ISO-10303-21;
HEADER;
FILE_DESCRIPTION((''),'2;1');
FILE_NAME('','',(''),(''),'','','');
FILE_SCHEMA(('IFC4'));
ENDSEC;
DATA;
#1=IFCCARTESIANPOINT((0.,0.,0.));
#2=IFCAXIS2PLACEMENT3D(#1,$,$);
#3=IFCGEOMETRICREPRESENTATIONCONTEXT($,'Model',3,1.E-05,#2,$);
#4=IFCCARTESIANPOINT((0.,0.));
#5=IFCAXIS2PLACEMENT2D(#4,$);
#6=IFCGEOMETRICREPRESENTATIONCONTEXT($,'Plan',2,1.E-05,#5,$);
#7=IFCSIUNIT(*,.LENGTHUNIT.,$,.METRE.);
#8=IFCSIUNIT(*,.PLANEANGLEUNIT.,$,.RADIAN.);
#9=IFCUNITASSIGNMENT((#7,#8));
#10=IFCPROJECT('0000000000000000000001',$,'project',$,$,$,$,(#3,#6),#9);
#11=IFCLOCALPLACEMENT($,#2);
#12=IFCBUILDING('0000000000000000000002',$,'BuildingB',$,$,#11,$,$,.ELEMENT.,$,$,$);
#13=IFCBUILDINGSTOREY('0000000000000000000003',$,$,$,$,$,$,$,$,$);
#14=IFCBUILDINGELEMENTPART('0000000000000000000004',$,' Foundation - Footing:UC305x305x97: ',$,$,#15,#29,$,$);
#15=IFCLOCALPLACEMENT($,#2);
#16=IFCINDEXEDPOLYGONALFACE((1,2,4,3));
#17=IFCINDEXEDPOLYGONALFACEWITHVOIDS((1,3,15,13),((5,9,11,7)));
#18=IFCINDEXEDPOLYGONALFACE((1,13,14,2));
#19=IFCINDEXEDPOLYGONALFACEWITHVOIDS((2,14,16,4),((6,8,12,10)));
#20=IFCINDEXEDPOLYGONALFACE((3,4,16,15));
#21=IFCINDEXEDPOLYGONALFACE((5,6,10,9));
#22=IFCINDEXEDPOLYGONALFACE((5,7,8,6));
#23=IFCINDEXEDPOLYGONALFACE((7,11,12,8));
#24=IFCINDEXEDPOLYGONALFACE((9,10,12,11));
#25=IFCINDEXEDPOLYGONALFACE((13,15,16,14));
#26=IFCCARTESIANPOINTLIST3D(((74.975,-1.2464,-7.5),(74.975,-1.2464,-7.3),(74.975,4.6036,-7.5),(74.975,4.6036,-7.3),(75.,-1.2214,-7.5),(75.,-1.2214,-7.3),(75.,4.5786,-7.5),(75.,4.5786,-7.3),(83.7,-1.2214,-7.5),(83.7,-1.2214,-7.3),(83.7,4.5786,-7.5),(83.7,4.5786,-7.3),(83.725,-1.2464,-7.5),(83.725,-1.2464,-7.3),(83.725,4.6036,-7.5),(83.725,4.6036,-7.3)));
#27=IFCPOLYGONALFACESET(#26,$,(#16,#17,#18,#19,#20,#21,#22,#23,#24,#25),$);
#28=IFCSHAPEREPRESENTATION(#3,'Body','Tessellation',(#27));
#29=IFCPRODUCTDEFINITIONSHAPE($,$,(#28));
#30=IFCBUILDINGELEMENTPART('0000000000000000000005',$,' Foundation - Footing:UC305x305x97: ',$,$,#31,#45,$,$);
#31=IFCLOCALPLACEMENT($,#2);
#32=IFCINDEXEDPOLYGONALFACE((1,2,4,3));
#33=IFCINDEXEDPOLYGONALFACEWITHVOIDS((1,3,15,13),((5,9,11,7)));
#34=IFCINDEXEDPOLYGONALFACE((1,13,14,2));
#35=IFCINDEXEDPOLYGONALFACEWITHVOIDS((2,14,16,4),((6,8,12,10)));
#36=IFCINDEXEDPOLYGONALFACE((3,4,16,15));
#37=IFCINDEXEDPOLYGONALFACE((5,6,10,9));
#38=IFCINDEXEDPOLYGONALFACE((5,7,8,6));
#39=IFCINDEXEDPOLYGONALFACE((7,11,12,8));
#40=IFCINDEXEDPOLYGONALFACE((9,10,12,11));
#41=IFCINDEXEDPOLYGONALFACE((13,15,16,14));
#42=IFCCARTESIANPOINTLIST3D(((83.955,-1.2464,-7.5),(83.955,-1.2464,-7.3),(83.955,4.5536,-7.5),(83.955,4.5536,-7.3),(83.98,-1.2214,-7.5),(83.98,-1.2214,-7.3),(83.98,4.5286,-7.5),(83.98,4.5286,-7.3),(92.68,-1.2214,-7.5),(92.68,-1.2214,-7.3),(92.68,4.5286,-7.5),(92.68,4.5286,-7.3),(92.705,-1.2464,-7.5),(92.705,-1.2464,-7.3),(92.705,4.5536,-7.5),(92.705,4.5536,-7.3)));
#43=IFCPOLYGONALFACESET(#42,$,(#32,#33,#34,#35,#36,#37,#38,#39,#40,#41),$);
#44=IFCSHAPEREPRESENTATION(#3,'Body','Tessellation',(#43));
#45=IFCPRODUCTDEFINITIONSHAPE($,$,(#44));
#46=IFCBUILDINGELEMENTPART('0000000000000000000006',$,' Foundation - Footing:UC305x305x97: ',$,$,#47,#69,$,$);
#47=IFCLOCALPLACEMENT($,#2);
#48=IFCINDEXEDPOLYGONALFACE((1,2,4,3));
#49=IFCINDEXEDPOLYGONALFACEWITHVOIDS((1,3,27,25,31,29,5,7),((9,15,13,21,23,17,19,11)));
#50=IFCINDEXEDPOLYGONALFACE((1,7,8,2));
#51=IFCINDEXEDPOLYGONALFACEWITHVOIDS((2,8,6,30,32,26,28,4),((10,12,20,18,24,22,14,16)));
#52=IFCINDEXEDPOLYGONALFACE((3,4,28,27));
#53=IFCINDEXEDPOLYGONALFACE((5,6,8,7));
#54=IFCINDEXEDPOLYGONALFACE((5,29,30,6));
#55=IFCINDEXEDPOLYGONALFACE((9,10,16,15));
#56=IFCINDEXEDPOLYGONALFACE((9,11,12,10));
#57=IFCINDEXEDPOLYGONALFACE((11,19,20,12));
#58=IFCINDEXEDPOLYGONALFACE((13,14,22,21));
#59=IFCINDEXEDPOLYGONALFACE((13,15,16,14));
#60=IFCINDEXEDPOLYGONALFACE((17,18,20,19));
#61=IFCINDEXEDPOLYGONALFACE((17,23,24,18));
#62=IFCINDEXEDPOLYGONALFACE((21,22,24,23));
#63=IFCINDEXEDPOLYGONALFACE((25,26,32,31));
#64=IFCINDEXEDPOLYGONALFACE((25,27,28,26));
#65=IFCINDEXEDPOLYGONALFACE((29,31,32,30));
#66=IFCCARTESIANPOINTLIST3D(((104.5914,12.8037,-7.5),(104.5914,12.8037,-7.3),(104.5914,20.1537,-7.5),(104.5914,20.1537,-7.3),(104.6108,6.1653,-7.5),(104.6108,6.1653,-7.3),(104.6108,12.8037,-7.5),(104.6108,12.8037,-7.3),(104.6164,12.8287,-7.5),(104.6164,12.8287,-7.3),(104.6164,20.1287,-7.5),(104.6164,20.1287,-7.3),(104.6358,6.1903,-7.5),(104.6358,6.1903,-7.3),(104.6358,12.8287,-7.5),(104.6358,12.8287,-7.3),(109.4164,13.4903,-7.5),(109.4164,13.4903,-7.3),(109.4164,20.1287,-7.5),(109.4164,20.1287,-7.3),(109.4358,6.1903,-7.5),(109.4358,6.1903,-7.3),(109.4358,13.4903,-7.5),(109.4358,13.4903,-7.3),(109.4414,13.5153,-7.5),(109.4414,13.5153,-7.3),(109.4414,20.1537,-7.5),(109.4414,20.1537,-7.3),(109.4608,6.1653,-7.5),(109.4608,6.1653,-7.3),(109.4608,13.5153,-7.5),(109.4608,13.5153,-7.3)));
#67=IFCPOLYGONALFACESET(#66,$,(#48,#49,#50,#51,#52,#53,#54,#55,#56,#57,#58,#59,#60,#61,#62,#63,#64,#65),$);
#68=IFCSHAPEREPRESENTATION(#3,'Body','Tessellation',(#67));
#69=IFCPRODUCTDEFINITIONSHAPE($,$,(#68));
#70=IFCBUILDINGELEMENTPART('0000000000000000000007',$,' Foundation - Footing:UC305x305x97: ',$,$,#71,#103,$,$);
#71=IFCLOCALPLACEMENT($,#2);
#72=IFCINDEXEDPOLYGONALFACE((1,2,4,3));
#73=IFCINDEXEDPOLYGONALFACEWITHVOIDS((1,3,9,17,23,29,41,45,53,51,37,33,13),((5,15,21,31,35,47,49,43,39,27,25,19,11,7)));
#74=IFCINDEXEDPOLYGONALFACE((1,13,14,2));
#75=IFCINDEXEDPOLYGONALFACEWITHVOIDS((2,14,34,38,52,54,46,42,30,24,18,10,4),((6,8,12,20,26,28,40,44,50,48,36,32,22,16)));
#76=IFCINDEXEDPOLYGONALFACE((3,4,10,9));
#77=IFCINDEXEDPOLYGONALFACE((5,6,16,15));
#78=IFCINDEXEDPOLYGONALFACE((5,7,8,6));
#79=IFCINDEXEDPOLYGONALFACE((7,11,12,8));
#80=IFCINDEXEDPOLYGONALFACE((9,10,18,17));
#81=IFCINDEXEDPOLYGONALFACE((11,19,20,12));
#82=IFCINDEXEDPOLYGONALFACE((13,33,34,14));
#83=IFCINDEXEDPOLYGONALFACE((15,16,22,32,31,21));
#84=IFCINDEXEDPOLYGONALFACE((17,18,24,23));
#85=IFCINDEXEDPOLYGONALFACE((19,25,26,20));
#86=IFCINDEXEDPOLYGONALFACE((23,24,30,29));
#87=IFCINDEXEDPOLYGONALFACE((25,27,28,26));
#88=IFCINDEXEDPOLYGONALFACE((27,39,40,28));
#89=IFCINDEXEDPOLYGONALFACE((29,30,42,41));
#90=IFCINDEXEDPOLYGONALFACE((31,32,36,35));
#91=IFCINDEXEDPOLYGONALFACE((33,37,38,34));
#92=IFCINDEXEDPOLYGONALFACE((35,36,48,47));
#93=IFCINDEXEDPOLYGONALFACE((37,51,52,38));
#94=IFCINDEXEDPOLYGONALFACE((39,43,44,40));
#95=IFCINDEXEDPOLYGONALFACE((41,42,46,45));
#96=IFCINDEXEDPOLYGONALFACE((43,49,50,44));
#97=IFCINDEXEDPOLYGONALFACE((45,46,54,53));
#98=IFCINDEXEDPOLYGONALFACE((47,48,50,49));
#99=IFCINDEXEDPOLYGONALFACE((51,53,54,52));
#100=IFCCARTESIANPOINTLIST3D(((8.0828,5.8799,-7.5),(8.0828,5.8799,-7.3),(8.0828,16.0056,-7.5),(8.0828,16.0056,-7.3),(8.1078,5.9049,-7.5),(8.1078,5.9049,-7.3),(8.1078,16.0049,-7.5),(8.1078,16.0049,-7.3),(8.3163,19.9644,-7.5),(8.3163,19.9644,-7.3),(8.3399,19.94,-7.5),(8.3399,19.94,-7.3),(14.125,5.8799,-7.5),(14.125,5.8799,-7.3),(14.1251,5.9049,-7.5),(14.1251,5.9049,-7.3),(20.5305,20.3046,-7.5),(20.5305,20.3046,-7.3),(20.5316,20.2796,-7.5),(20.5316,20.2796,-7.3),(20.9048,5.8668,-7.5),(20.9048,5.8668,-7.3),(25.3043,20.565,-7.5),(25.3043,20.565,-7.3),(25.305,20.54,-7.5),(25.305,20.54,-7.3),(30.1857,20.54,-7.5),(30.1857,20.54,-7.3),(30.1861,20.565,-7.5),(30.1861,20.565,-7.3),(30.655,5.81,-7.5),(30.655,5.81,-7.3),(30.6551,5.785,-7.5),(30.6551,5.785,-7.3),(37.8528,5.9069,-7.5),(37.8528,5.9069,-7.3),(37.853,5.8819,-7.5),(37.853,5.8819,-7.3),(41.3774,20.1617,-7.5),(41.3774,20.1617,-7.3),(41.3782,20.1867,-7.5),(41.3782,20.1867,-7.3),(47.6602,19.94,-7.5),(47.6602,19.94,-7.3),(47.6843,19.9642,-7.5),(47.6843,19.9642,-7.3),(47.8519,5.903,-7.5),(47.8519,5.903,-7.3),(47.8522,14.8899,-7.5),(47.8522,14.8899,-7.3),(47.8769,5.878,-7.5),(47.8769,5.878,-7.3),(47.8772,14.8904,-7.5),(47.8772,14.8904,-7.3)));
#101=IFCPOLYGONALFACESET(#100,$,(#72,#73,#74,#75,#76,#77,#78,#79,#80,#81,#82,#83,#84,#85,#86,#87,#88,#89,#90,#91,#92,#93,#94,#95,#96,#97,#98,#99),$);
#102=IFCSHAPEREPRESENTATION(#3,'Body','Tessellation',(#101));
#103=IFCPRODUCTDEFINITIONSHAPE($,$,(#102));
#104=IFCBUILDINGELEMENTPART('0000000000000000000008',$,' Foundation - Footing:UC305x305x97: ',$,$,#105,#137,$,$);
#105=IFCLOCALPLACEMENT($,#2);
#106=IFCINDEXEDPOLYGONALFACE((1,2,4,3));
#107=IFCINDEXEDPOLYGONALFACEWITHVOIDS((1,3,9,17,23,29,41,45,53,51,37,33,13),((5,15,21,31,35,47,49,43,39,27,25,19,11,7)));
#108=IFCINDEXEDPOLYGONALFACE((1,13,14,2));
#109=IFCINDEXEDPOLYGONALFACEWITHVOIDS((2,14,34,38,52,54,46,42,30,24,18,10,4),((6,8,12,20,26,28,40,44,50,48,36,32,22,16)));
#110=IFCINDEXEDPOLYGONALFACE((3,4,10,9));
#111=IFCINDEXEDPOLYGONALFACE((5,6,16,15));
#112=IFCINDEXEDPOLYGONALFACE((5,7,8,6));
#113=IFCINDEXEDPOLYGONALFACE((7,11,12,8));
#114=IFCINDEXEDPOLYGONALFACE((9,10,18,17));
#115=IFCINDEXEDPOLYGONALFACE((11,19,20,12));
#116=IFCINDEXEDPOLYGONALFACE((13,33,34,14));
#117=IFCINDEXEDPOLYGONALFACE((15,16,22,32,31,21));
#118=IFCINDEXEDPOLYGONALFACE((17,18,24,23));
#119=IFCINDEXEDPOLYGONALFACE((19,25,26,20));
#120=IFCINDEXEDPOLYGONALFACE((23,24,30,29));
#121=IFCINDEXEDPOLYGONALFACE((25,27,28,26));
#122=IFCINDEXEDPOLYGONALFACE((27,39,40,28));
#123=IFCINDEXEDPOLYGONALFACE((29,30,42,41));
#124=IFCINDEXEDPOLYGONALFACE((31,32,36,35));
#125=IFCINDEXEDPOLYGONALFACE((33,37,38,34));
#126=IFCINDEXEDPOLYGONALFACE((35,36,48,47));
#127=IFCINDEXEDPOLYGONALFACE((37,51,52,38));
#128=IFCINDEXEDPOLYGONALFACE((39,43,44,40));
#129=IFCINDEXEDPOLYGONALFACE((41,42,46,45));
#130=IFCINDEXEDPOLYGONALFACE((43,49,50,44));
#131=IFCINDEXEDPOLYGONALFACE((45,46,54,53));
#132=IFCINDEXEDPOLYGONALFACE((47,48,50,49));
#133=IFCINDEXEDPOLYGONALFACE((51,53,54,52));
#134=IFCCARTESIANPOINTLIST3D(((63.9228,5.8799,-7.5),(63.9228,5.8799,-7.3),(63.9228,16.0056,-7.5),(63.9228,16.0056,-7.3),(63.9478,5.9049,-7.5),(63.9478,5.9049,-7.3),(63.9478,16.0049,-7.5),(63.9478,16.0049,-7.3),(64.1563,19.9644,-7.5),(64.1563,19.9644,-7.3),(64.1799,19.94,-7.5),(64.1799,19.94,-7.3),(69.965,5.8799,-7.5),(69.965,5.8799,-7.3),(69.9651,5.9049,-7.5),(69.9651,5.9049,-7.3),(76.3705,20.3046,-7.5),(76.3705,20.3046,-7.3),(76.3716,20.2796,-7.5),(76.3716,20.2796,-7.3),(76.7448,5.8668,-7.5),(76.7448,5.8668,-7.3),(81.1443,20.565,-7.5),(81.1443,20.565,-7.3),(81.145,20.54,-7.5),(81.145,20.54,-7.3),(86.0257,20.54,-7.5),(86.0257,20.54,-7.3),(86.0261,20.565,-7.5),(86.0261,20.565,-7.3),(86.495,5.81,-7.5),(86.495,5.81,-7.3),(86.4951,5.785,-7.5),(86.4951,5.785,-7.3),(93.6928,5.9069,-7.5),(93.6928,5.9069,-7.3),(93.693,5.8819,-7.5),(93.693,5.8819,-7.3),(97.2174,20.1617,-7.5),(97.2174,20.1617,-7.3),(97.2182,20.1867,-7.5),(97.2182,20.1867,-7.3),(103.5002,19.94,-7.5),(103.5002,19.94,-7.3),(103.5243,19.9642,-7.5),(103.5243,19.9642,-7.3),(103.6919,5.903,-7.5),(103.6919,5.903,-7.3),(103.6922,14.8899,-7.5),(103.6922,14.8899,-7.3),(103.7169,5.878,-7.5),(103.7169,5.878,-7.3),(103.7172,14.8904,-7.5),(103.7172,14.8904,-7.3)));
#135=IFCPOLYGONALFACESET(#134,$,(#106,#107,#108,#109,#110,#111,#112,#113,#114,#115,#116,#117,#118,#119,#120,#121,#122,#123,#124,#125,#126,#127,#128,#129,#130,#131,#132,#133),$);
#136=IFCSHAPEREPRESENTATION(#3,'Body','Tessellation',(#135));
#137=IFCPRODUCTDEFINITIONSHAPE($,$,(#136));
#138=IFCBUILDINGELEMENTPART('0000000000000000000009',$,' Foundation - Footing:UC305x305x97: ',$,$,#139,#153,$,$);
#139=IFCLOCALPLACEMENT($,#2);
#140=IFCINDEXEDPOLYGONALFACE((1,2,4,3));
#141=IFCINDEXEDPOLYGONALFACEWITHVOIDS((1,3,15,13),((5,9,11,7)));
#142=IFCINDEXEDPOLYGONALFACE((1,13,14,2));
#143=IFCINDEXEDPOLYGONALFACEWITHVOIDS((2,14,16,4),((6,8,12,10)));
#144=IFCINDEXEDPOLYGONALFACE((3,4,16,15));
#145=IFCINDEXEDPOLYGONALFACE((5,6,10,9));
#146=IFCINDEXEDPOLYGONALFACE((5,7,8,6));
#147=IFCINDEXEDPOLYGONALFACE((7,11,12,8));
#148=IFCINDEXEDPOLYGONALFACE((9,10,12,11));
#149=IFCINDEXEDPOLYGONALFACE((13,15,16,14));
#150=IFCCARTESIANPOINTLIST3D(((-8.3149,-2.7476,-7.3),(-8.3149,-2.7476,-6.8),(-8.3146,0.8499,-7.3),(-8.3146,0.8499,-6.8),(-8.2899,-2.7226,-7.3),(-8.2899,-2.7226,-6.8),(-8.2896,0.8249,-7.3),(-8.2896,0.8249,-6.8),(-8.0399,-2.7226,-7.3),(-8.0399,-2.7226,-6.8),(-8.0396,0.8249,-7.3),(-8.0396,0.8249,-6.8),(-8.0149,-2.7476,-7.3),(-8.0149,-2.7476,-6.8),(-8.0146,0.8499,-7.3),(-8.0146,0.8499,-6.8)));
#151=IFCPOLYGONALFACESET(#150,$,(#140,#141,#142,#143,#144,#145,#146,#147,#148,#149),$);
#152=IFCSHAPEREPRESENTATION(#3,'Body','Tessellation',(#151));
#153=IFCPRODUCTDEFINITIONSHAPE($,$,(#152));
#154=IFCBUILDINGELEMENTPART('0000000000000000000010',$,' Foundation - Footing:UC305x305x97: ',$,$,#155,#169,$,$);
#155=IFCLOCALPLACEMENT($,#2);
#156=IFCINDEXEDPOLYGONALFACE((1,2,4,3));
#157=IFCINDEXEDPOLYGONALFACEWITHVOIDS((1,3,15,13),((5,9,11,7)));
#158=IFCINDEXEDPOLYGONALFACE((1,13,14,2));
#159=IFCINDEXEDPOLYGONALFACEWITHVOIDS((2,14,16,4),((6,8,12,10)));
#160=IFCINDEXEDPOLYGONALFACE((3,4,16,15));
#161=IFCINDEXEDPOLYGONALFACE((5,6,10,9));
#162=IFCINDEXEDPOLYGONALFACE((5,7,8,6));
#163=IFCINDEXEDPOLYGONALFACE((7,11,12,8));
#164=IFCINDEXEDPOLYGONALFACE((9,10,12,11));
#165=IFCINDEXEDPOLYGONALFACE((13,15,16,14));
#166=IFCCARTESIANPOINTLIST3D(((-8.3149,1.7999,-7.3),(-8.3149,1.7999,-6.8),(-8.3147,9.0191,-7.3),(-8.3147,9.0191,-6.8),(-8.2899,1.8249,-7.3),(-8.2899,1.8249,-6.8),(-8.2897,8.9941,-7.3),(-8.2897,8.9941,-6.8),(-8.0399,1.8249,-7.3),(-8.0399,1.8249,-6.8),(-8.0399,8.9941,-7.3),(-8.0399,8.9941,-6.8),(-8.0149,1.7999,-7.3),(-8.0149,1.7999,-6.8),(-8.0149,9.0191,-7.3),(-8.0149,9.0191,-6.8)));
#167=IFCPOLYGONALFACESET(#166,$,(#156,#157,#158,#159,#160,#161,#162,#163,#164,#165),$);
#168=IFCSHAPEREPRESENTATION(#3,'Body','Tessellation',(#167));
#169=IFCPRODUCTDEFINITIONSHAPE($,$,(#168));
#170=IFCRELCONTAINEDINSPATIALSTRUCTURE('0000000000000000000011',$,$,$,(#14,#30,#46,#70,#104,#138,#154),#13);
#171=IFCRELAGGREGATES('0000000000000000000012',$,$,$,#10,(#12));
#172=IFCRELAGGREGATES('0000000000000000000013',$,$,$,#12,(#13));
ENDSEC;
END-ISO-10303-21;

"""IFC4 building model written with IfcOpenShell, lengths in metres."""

from ifc_helpers import new_model, si_unit, origin, origin_2d, place, context, project, spatial, polyline, outline, extrude, element, save


model = new_model("IFC4")

# Units and contexts
model_context = context("Model", 3, precision=1e-05, world=origin())
plan_context = context("Plan", 2, precision=1e-05, world=origin_2d())
ifc_project = project(units=[si_unit("LENGTHUNIT", "METRE"), si_unit("PLANEANGLEUNIT", "RADIAN")], contexts=[model_context, plan_context])

# Building, storey
building_placement = place(None, origin())
building = spatial("IfcBuilding", under=ifc_project, at=building_placement, Name="BuildingB", CompositionType="ELEMENT")
storey = spatial("IfcBuildingStorey", under=building)

# Building element parts, openings
building_element_part_1 = element("IfcBuildingElementPart", 1, inside=storey, Name=" Foundation - Footing:UC305x305x97: ", context=model_context, shape_type="SweptSolid", body=[
    extrude(outline(polyline([(74.975, -1.2464, -7.5), (83.725, -1.2464, -7.5), (83.725, 4.6036, -7.5), (74.975, 4.6036, -7.5), (74.975, -1.2464, -7.5)])), None, (0.0, 0.0, 1.0), 0.2),
])
element("IfcOpeningElement", 2, inside=storey, cuts=building_element_part_1, context=model_context, shape_type="SweptSolid", body=[
    extrude(outline(polyline([(75.0, -1.2214, -7.5), (83.7, -1.2214, -7.5), (83.7, 4.5786, -7.5), (75.0, 4.5786, -7.5), (75.0, -1.2214, -7.5)])), None, (0.0, 0.0, 1.0), 0.2),
])
building_element_part_2 = element("IfcBuildingElementPart", 3, inside=storey, Name=" Foundation - Footing:UC305x305x97: ", context=model_context, shape_type="SweptSolid", body=[
    extrude(outline(polyline([(92.705, -1.2464, -7.5), (83.955, -1.2464, -7.5), (83.955, 4.5536, -7.5), (92.705, 4.5536, -7.5), (92.705, -1.2464, -7.5)])), None, (0.0, 0.0, 1.0), 0.2),
])
element("IfcOpeningElement", 4, inside=storey, cuts=building_element_part_2, context=model_context, shape_type="SweptSolid", body=[
    extrude(outline(polyline([(92.68, -1.2214, -7.5), (83.98, -1.2214, -7.5), (83.98, 4.5286, -7.5), (92.68, 4.5286, -7.5), (92.68, -1.2214, -7.5)])), None, (0.0, 0.0, 1.0), 0.2),
])
building_element_part_3 = element("IfcBuildingElementPart", 5, inside=storey, Name=" Foundation - Footing:UC305x305x97: ", context=model_context, shape_type="SweptSolid", body=[
    extrude(outline(polyline([(104.6108, 12.8037, -7.5), (104.5914, 12.8037, -7.5), (104.5914, 15.1899, -7.5), (104.5914, 20.1537, -7.5), (109.4414, 20.1537, -7.5), (109.4414, 17.04, -7.5), (109.4414, 13.5153, -7.5), (109.4608, 13.5153, -7.5), (109.4608, 9.16, -7.5), (109.4608, 6.1653, -7.5), (106.4755, 6.1653, -7.5), (104.6108, 6.1653, -7.5), (104.6108, 9.3099, -7.5), (104.6108, 12.8037, -7.5)])), None, (0.0, 0.0, 1.0), 0.2),
])
element("IfcOpeningElement", 6, inside=storey, cuts=building_element_part_3, context=model_context, shape_type="SweptSolid", body=[
    extrude(outline(polyline([(104.6358, 12.8287, -7.5), (104.6164, 12.8287, -7.5), (104.6164, 15.1899, -7.5), (104.6164, 20.1287, -7.5), (109.4164, 20.1287, -7.5), (109.4164, 17.04, -7.5), (109.4164, 13.4903, -7.5), (109.4358, 13.4903, -7.5), (109.4358, 9.16, -7.5), (109.4358, 6.1903, -7.5), (106.4755, 6.1903, -7.5), (104.6358, 6.1903, -7.5), (104.6358, 9.3099, -7.5), (104.6358, 12.8287, -7.5)])), None, (0.0, 0.0, 1.0), 0.2),
])
building_element_part_4 = element("IfcBuildingElementPart", 7, inside=storey, Name=" Foundation - Footing:UC305x305x97: ", context=model_context, shape_type="SweptSolid", body=[
    extrude(outline(polyline([(8.3163, 19.9644, -7.5), (20.5305, 20.3046, -7.5), (25.3043, 20.565, -7.5), (30.1861, 20.565, -7.5), (41.3782, 20.1867, -7.5), (47.6843, 19.9642, -7.5), (47.8772, 14.8904, -7.5), (47.8769, 5.878, -7.5), (37.853, 5.8819, -7.5), (30.6551, 5.785, -7.5), (20.9046, 5.8418, -7.5), (14.125, 5.8799, -7.5), (8.0828, 5.8799, -7.5), (8.0828, 16.0056, -7.5), (8.3163, 19.9644, -7.5)])), None, (0.0, 0.0, 1.0), 0.2),
])
element("IfcOpeningElement", 8, inside=storey, cuts=building_element_part_4, context=model_context, shape_type="SweptSolid", body=[
    extrude(outline(polyline([(8.3399, 19.94, -7.5), (20.5316, 20.2796, -7.5), (25.305, 20.54, -7.5), (30.1857, 20.54, -7.5), (41.3774, 20.1617, -7.5), (47.6602, 19.94, -7.5), (47.8522, 14.8899, -7.5), (47.8519, 5.903, -7.5), (37.8528, 5.9069, -7.5), (30.655, 5.81, -7.5), (20.9048, 5.8668, -7.5), (14.1251, 5.9049, -7.5), (8.1078, 5.9049, -7.5), (8.1078, 16.0049, -7.5), (8.3399, 19.94, -7.5)])), None, (0.0, 0.0, 1.0), 0.2),
])
building_element_part_5 = element("IfcBuildingElementPart", 9, inside=storey, Name=" Foundation - Footing:UC305x305x97: ", context=model_context, shape_type="SweptSolid", body=[
    extrude(outline(polyline([(64.1563, 19.9644, -7.5), (76.3705, 20.3046, -7.5), (81.1443, 20.565, -7.5), (86.0261, 20.565, -7.5), (97.2182, 20.1867, -7.5), (103.5243, 19.9642, -7.5), (103.7172, 14.8904, -7.5), (103.7169, 5.878, -7.5), (93.693, 5.8819, -7.5), (86.4951, 5.785, -7.5), (76.7446, 5.8418, -7.5), (69.965, 5.8799, -7.5), (63.9228, 5.8799, -7.5), (63.9228, 16.0056, -7.5), (64.1563, 19.9644, -7.5)])), None, (0.0, 0.0, 1.0), 0.2),
])
element("IfcOpeningElement", 10, inside=storey, cuts=building_element_part_5, context=model_context, shape_type="SweptSolid", body=[
    extrude(outline(polyline([(64.1799, 19.94, -7.5), (76.3716, 20.2796, -7.5), (81.145, 20.54, -7.5), (86.0257, 20.54, -7.5), (97.2174, 20.1617, -7.5), (103.5002, 19.94, -7.5), (103.6922, 14.8899, -7.5), (103.6919, 5.903, -7.5), (93.6928, 5.9069, -7.5), (86.495, 5.81, -7.5), (76.7448, 5.8668, -7.5), (69.9651, 5.9049, -7.5), (63.9478, 5.9049, -7.5), (63.9478, 16.0049, -7.5), (64.1799, 19.94, -7.5)])), None, (0.0, 0.0, 1.0), 0.2),
])
building_element_part_6 = element("IfcBuildingElementPart", 11, inside=storey, Name=" Foundation - Footing:UC305x305x97: ", context=model_context, shape_type="SweptSolid", body=[
    extrude(outline(polyline([(-8.3149, -2.7476, -7.3), (-8.0149, -2.7476, -7.3), (-8.0146, 0.8499, -7.3), (-8.3146, 0.8499, -7.3), (-8.3149, -2.7476, -7.3)])), None, (0.0, 0.0, 1.0), 0.5),
])
element("IfcOpeningElement", 12, inside=storey, cuts=building_element_part_6, context=model_context, shape_type="SweptSolid", body=[
    extrude(outline(polyline([(-8.2899, -2.7226, -7.3), (-8.0399, -2.7226, -7.3), (-8.0396, 0.8249, -7.3), (-8.2896, 0.8249, -7.3), (-8.2899, -2.7226, -7.3)])), None, (0.0, 0.0, 1.0), 0.5),
])
building_element_part_7 = element("IfcBuildingElementPart", 13, inside=storey, Name=" Foundation - Footing:UC305x305x97: ", context=model_context, shape_type="SweptSolid", body=[
    extrude(outline(polyline([(-8.3149, 1.7999, -7.3), (-8.0149, 1.7999, -7.3), (-8.0149, 9.0191, -7.3), (-8.3147, 9.0191, -7.3), (-8.3149, 1.7999, -7.3)])), None, (0.0, 0.0, 1.0), 0.5),
])
element("IfcOpeningElement", 14, inside=storey, cuts=building_element_part_7, context=model_context, shape_type="SweptSolid", body=[
    extrude(outline(polyline([(-8.2899, 1.8249, -7.3), (-8.0399, 1.8249, -7.3), (-8.0399, 8.9941, -7.3), (-8.2897, 8.9941, -7.3), (-8.2899, 1.8249, -7.3)])), None, (0.0, 0.0, 1.0), 0.5),
])

save(model, "model.ifc")
